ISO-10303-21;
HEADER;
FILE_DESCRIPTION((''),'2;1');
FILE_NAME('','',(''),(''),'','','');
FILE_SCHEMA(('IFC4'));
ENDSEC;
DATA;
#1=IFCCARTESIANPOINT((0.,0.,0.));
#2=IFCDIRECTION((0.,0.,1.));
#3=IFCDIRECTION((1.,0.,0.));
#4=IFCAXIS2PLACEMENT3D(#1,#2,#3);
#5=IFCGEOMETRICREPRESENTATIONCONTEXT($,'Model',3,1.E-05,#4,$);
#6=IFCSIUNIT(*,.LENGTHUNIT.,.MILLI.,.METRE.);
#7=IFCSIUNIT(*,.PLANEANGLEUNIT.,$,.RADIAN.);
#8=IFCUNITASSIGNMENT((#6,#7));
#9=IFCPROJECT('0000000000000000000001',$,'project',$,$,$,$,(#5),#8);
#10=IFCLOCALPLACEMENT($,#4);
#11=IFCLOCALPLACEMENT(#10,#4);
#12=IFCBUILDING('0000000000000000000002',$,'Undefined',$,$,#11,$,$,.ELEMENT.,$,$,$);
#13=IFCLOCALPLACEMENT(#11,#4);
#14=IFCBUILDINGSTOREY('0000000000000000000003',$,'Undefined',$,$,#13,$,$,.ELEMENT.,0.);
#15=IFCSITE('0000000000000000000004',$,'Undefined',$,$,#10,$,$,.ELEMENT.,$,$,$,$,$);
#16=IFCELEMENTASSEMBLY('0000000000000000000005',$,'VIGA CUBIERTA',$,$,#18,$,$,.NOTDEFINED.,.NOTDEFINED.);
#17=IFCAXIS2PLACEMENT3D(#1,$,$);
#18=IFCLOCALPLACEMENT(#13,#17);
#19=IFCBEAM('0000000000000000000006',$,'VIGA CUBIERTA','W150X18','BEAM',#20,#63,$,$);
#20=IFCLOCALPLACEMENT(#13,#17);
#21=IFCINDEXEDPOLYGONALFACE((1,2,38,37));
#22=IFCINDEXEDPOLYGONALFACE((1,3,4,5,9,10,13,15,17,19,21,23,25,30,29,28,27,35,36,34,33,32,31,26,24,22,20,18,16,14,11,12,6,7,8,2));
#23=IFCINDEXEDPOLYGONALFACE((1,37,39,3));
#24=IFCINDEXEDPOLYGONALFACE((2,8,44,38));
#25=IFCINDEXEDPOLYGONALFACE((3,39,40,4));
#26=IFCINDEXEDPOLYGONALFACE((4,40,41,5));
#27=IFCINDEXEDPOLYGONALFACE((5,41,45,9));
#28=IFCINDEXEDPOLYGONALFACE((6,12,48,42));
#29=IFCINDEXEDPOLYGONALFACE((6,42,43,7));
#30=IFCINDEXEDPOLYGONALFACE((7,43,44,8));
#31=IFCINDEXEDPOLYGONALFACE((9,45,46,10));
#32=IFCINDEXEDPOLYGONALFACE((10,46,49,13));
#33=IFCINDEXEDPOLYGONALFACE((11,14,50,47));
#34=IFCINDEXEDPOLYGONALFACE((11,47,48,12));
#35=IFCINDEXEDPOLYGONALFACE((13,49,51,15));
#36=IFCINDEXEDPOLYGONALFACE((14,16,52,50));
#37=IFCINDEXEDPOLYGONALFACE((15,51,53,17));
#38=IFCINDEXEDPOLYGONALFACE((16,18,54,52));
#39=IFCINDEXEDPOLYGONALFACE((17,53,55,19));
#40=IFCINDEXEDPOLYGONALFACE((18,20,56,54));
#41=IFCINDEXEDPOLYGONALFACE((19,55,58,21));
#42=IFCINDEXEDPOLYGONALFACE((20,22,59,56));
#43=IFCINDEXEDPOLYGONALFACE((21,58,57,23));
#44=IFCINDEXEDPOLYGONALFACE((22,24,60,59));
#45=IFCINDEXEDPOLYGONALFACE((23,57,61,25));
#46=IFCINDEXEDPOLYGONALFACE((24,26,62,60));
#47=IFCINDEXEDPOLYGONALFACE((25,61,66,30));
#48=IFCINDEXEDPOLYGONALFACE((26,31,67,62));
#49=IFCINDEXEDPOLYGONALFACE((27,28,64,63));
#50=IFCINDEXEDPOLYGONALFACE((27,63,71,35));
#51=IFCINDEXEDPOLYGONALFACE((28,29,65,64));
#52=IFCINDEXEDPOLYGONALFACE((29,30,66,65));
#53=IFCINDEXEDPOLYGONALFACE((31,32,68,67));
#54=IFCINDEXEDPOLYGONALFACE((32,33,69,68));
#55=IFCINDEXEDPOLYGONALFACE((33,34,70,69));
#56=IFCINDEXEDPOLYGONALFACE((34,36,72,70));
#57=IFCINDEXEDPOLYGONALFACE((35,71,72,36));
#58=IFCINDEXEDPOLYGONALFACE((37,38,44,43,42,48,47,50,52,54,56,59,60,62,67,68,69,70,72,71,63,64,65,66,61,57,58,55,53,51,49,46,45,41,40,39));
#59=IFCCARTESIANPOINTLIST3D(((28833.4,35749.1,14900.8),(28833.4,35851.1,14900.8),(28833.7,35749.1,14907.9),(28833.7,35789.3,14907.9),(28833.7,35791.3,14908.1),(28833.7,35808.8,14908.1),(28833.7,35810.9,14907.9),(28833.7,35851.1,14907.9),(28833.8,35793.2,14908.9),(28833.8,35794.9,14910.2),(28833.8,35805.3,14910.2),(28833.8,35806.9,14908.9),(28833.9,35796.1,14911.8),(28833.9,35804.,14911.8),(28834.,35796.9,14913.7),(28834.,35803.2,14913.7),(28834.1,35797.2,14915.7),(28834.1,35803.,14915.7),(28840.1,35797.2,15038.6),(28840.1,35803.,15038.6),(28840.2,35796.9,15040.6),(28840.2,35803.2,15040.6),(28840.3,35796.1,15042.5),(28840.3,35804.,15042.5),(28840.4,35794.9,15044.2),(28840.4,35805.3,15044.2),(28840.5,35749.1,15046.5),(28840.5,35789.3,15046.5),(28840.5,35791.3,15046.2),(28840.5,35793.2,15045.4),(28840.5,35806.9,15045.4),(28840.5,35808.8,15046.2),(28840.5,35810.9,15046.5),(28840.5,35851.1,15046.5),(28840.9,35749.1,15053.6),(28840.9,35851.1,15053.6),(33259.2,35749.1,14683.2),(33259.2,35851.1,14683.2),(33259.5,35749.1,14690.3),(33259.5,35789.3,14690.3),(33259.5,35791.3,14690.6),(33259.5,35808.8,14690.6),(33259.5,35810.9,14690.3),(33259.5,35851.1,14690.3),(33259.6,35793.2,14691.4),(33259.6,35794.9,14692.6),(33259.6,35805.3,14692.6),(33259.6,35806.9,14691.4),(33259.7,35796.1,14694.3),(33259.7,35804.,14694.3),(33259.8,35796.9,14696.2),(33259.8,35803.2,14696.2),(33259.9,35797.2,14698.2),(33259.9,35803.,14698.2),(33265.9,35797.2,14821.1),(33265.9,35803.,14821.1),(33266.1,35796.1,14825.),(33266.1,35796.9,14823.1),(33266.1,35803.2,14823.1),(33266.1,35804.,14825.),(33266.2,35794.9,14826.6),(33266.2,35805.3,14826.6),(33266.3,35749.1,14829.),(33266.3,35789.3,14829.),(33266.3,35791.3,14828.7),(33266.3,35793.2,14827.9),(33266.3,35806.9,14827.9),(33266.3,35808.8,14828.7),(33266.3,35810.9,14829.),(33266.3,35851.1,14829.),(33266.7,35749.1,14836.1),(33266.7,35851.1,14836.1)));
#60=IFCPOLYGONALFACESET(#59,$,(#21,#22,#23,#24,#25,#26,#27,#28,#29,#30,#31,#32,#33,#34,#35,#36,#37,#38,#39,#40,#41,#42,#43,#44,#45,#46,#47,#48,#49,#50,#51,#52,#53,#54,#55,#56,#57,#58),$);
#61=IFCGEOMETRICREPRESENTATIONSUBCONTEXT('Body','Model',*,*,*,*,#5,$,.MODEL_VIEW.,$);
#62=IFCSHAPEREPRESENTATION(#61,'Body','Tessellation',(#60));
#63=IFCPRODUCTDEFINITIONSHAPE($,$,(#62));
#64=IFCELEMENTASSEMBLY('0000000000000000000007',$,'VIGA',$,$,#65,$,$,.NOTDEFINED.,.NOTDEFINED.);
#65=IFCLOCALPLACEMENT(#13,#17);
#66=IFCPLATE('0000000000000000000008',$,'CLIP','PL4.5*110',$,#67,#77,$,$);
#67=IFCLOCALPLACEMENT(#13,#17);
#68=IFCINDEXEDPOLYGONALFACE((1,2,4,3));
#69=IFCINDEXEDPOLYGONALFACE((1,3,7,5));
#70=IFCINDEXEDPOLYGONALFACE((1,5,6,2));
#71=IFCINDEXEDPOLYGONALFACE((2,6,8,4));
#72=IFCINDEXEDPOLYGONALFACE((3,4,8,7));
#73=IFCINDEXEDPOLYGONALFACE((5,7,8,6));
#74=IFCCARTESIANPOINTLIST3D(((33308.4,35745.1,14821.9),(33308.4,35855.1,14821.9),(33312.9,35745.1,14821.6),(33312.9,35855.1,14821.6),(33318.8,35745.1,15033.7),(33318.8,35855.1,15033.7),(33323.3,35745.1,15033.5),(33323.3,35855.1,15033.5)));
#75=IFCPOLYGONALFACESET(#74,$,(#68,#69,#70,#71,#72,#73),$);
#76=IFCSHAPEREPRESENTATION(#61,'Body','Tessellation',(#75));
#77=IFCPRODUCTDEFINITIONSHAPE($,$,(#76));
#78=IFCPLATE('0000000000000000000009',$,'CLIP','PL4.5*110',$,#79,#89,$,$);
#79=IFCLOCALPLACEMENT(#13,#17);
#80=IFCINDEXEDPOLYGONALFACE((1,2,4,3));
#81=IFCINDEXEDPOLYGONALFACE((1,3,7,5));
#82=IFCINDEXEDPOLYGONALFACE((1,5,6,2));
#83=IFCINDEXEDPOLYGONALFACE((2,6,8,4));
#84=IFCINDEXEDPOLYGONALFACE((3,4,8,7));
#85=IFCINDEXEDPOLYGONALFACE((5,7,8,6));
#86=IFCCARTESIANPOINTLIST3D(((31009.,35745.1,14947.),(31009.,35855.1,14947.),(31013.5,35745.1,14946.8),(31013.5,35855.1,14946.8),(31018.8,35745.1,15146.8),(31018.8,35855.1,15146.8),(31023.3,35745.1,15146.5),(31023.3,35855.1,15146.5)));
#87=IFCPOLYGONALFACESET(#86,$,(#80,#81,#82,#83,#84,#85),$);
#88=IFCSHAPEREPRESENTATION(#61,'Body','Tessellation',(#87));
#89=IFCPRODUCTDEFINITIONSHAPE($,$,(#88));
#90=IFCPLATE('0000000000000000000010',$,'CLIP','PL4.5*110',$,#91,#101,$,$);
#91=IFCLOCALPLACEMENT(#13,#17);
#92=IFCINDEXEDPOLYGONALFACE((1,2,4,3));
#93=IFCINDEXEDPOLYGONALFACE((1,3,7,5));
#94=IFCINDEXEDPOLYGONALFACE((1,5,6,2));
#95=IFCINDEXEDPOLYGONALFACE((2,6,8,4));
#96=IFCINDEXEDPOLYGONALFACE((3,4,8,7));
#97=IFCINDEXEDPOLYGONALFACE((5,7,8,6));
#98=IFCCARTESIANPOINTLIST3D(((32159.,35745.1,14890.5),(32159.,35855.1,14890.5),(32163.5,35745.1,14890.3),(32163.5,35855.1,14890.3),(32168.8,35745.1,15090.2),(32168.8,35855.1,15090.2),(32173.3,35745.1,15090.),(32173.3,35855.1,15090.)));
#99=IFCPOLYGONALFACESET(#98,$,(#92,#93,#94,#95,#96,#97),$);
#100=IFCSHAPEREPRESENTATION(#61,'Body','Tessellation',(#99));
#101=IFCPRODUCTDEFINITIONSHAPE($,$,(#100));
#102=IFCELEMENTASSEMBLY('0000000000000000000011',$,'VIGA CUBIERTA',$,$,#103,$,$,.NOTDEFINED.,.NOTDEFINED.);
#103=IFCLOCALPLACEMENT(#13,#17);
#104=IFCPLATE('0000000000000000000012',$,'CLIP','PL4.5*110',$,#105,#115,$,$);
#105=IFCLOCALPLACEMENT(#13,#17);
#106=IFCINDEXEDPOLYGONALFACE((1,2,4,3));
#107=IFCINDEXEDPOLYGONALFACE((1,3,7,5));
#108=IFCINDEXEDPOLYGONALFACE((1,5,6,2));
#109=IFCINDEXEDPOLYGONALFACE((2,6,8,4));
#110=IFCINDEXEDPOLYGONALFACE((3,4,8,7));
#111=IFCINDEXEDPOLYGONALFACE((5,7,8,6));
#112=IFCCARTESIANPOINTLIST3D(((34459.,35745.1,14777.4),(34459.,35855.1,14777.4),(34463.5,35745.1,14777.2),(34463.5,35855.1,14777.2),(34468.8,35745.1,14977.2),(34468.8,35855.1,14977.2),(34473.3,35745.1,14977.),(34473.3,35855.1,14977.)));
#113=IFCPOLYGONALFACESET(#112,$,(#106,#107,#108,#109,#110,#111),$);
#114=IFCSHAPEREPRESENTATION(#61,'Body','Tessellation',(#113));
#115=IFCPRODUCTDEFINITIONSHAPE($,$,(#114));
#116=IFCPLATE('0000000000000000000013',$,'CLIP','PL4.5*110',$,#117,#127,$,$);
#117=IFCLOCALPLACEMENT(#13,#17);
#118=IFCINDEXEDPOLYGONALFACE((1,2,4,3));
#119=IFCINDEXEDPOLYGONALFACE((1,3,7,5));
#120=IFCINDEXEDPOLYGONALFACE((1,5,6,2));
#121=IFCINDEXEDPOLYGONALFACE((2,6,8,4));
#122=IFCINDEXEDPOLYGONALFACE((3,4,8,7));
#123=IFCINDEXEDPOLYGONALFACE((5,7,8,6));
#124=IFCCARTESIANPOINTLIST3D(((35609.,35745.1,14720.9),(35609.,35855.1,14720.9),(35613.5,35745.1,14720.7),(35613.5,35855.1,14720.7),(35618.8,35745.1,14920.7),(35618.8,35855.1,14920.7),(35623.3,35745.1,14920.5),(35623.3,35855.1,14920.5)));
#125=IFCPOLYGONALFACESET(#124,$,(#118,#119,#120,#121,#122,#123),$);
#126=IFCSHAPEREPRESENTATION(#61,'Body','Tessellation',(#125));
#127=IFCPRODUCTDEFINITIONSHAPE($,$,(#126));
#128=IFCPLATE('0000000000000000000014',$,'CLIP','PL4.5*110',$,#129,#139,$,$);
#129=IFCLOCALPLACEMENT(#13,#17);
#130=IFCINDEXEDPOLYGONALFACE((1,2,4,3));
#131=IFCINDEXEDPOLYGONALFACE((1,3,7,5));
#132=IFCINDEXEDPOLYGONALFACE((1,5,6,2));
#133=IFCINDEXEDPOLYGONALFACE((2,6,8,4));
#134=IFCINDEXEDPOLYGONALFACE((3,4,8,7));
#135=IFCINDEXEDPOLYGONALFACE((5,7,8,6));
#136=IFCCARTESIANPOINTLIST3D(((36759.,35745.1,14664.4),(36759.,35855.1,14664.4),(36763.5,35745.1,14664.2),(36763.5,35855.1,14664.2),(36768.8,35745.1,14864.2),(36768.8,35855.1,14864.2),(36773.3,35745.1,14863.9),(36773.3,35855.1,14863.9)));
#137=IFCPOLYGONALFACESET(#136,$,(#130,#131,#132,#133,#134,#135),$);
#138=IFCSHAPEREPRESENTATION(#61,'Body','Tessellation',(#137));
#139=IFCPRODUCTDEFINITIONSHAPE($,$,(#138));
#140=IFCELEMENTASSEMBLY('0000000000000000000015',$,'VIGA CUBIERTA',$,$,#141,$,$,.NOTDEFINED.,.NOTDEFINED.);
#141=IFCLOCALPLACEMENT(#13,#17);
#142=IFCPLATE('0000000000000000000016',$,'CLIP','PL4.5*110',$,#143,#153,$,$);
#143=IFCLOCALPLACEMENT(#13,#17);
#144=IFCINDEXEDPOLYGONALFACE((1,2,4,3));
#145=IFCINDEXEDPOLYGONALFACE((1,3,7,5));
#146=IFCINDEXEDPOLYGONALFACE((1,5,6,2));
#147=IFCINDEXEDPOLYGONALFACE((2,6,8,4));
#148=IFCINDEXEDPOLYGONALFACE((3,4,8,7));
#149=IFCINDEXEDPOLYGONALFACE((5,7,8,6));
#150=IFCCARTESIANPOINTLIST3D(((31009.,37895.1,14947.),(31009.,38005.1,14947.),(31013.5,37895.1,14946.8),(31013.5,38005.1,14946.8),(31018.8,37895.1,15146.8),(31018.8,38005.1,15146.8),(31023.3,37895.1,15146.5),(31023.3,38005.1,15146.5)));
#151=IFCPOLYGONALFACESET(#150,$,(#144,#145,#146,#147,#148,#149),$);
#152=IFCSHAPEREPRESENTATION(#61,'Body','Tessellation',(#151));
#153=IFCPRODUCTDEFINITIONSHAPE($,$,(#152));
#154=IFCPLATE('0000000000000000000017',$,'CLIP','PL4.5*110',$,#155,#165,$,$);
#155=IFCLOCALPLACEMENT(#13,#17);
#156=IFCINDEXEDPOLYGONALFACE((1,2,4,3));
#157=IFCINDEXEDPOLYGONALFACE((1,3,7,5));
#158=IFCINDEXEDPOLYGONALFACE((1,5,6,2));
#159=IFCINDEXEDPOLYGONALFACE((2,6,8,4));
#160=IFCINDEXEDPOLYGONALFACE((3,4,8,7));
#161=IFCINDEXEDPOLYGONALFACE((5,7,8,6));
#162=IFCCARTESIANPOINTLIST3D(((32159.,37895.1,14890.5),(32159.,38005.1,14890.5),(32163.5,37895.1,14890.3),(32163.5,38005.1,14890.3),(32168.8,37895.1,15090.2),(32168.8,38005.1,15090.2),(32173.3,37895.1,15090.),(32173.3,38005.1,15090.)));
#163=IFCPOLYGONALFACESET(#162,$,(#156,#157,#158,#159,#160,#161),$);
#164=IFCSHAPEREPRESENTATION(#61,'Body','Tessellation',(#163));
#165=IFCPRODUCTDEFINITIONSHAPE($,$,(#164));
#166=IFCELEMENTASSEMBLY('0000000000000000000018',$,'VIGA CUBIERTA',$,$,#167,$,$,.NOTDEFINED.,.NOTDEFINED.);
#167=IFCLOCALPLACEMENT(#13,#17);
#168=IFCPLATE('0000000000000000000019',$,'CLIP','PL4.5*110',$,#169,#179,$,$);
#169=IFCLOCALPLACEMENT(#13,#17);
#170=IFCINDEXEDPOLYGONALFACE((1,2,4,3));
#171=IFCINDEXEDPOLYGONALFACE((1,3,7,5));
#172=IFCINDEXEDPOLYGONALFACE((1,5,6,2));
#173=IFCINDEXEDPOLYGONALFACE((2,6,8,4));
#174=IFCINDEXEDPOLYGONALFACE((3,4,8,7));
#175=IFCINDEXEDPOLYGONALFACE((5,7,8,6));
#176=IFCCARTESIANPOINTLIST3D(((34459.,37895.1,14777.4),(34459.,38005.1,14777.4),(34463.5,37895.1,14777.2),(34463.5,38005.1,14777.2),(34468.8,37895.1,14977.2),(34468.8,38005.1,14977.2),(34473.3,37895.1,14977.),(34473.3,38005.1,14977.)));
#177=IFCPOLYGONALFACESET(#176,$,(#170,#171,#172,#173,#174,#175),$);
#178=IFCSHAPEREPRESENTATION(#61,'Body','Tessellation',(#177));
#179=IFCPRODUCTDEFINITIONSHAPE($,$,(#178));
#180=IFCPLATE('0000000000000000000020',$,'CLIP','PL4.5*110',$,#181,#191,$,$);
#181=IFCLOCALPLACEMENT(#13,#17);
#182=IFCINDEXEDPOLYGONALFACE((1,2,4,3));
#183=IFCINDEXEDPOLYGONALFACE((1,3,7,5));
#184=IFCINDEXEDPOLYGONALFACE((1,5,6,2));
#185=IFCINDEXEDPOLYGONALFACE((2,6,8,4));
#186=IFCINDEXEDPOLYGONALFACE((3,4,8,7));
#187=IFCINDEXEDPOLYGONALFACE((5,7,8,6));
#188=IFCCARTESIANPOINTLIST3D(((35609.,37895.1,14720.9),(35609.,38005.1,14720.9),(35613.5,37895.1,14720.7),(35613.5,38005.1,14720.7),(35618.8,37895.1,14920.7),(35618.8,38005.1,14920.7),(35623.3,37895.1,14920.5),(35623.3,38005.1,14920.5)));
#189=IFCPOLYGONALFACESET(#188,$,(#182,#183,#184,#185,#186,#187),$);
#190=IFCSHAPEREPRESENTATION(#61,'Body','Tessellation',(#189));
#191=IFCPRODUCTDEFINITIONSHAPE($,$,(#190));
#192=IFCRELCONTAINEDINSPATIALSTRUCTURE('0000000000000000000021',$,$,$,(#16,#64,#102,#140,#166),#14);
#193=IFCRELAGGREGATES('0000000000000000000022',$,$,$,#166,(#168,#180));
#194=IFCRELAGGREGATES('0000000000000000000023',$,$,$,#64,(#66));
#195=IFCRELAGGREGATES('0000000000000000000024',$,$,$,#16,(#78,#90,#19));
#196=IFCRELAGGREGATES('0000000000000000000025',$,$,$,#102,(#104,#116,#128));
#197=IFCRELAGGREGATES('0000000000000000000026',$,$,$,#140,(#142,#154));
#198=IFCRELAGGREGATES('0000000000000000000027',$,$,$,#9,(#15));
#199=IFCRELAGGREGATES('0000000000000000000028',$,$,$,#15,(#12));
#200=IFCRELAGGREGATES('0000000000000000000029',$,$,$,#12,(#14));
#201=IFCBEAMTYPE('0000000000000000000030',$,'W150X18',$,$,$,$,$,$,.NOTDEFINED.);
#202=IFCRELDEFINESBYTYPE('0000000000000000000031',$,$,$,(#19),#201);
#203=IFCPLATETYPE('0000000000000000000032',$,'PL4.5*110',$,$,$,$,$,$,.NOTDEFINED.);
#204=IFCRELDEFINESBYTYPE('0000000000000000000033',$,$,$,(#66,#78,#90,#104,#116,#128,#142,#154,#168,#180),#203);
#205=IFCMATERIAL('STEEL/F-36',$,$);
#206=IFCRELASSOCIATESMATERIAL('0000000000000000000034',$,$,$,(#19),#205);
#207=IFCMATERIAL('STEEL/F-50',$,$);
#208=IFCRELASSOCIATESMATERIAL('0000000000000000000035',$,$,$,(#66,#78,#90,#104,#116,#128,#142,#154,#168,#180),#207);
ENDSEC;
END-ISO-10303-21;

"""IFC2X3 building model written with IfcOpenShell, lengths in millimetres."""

from ifc_helpers import new_model, si_unit, frame, origin_with_axes, origin_2d_with_axis, place, context, subcontext, project, spatial, polyline, i_section, outline, extrude, material, type_object, element, aggregate, save


model = new_model("IFC2X3")

# Units and contexts
model_context = context("Model", 3, precision=1e-05, world=origin_with_axes())
body_context = subcontext(model_context, "Body", "Model", "MODEL_VIEW")
ifc_project = project(units=[si_unit("LENGTHUNIT", "METRE", prefix="MILLI"), si_unit("PLANEANGLEUNIT", "RADIAN")], contexts=[model_context])

# Site, building, storey
site_placement = place(None, origin_with_axes())
site = spatial("IfcSite", under=ifc_project, at=site_placement, Name="Undefined", CompositionType="ELEMENT")
building_placement = place(site_placement, origin_with_axes())
building = spatial("IfcBuilding", under=site, at=building_placement, Name="Undefined", CompositionType="ELEMENT")
storey_placement = place(building_placement, origin_with_axes())
storey = spatial("IfcBuildingStorey", under=building, at=storey_placement, Name="Undefined", CompositionType="ELEMENT", Elevation=0.0)

# Element assembly, beam
assembly_1_placement = place(storey_placement, origin_with_axes())
assembly_1 = element("IfcElementAssembly", 1, at=assembly_1_placement, inside=storey, Name="VIGA CUBIERTA", AssemblyPlace="NOTDEFINED", PredefinedType="NOTDEFINED")
ifc_material_1 = material(Name="STEEL/F-36")
beam_type = type_object("IfcBeamType", Name="W150X18", PredefinedType="NOTDEFINED")
beam_placement = place(assembly_1_placement, frame((33262.9, 35800.1, 14759.6), z_axis=(0.04909, 0.0, 0.998794), x_axis=(-0.998794, 0.0, 0.04909)))
beam = element("IfcBeam", 2, at=beam_placement, type_object=beam_type, material=ifc_material_1, Name="VIGA CUBIERTA", Description="W150X18", ObjectType="BEAM", context=body_context, shape_type="SweptSolid", body=[
    extrude(i_section(OverallWidth=102.0, OverallDepth=153.0, WebThickness=5.8, FlangeThickness=7.1, FilletRadius=7.9, at=origin_2d_with_axis()), frame((4431.1, 0.0, 0.0), z_axis=(-1.0, 0.0, 0.0), x_axis=(0.0, -1.0, 0.0)), (0.0, 0.0, 1.0), 4431.1),
])

# Element assembly, plate
assembly_2_placement = place(storey_placement, origin_with_axes())
assembly_2 = element("IfcElementAssembly", 3, at=assembly_2_placement, inside=storey, Name="VIGA", AssemblyPlace="NOTDEFINED", PredefinedType="NOTDEFINED")
ifc_material_2 = material(Name="STEEL/F-50")
plate_type_1 = type_object("IfcPlateType", Name="PL4.5*110", PredefinedType="NOTDEFINED")
plate_1_placement = place(assembly_2_placement, frame((33310.6, 35745.1, 14821.8), z_axis=(0.998794, 0.0, -0.049091), x_axis=(0.0, 1.0, 0.0)))
plate_1 = element("IfcPlate", 4, at=plate_1_placement, type_object=plate_type_1, material=ifc_material_2, Name="CLIP", Description="PL4.5*110", context=body_context, shape_type="SweptSolid", body=[
    extrude(outline(polyline([(0.0, 0.0), (110.0, 0.0), (110.0, 212.1), (0.0, 212.1), (0.0, 0.0)])), frame((0.0, 0.0, -2.2), z_axis=(0.0, 0.0, 1.0), x_axis=(1.0, 0.0, 0.0)), (0.0, 0.0, 1.0), 4.5),
])

# Plates
plate_2_placement = place(assembly_1_placement, frame((31011.2, 35745.1, 14946.9), z_axis=(0.998794, 0.0, -0.049091), x_axis=(0.0, 1.0, 0.0)))
plate_2 = element("IfcPlate", 5, at=plate_2_placement, type_object=plate_type_1, material=ifc_material_2, Name="CLIP", Description="PL4.5*110", context=body_context, shape_type="SweptSolid", body=[
    extrude(outline(polyline([(0.0, 0.0), (110.0, 0.0), (110.0, 200.0), (0.0, 200.0), (0.0, 0.0)])), frame((0.0, 0.0, -2.2), z_axis=(0.0, 0.0, 1.0), x_axis=(1.0, 0.0, 0.0)), (0.0, 0.0, 1.0), 4.5),
])
plate_3_placement = place(assembly_1_placement, frame((32161.2, 35745.1, 14890.4), z_axis=(0.998794, 0.0, -0.049091), x_axis=(0.0, 1.0, 0.0)))
plate_3 = element("IfcPlate", 6, at=plate_3_placement, type_object=plate_type_1, material=ifc_material_2, Name="CLIP", Description="PL4.5*110", context=body_context, shape_type="SweptSolid", body=[
    extrude(outline(polyline([(0.0, 0.0), (110.0, 0.0), (110.0, 200.0), (0.0, 200.0), (0.0, 0.0)])), frame((0.0, 0.0, -2.2), z_axis=(0.0, 0.0, 1.0), x_axis=(1.0, 0.0, 0.0)), (0.0, 0.0, 1.0), 4.5),
])

# Element assemblies, plates
assembly_3_placement = place(storey_placement, origin_with_axes())
assembly_3 = element("IfcElementAssembly", 7, at=assembly_3_placement, inside=storey, Name="VIGA CUBIERTA", AssemblyPlace="NOTDEFINED", PredefinedType="NOTDEFINED")
plate_4_placement = place(assembly_3_placement, frame((34461.2, 35745.1, 14777.3), z_axis=(0.998794, 0.0, -0.049091), x_axis=(0.0, 1.0, 0.0)))
plate_4 = element("IfcPlate", 8, at=plate_4_placement, type_object=plate_type_1, material=ifc_material_2, Name="CLIP", Description="PL4.5*110", context=body_context, shape_type="SweptSolid", body=[
    extrude(outline(polyline([(0.0, 0.0), (110.0, 0.0), (110.0, 200.0), (0.0, 200.0), (0.0, 0.0)])), frame((0.0, 0.0, -2.2), z_axis=(0.0, 0.0, 1.0), x_axis=(1.0, 0.0, 0.0)), (0.0, 0.0, 1.0), 4.5),
])
plate_5_placement = place(assembly_3_placement, frame((35611.2, 35745.1, 14720.8), z_axis=(0.998794, 0.0, -0.049091), x_axis=(0.0, 1.0, 0.0)))
plate_5 = element("IfcPlate", 9, at=plate_5_placement, type_object=plate_type_1, material=ifc_material_2, Name="CLIP", Description="PL4.5*110", context=body_context, shape_type="SweptSolid", body=[
    extrude(outline(polyline([(0.0, 0.0), (110.0, 0.0), (110.0, 200.0), (0.0, 200.0), (0.0, 0.0)])), frame((0.0, 0.0, -2.2), z_axis=(0.0, 0.0, 1.0), x_axis=(1.0, 0.0, 0.0)), (0.0, 0.0, 1.0), 4.5),
])
plate_6_placement = place(assembly_3_placement, frame((36761.2, 35745.1, 14664.3), z_axis=(0.998794, 0.0, -0.049091), x_axis=(0.0, 1.0, 0.0)))
plate_6 = element("IfcPlate", 10, at=plate_6_placement, type_object=plate_type_1, material=ifc_material_2, Name="CLIP", Description="PL4.5*110", context=body_context, shape_type="SweptSolid", body=[
    extrude(outline(polyline([(0.0, 0.0), (110.0, 0.0), (110.0, 200.0), (0.0, 200.0), (0.0, 0.0)])), frame((0.0, 0.0, -2.2), z_axis=(0.0, 0.0, 1.0), x_axis=(1.0, 0.0, 0.0)), (0.0, 0.0, 1.0), 4.5),
])
assembly_4_placement = place(storey_placement, origin_with_axes())
assembly_4 = element("IfcElementAssembly", 11, at=assembly_4_placement, inside=storey, Name="VIGA CUBIERTA", AssemblyPlace="NOTDEFINED", PredefinedType="NOTDEFINED")
plate_7_placement = place(assembly_4_placement, frame((31011.2, 37895.1, 14946.9), z_axis=(0.998794, 0.0, -0.049091), x_axis=(0.0, 1.0, 0.0)))
plate_7 = element("IfcPlate", 12, at=plate_7_placement, type_object=plate_type_1, material=ifc_material_2, Name="CLIP", Description="PL4.5*110", context=body_context, shape_type="SweptSolid", body=[
    extrude(outline(polyline([(0.0, 0.0), (110.0, 0.0), (110.0, 200.0), (0.0, 200.0), (0.0, 0.0)])), frame((0.0, 0.0, -2.2), z_axis=(0.0, 0.0, 1.0), x_axis=(1.0, 0.0, 0.0)), (0.0, 0.0, 1.0), 4.5),
])
plate_8_placement = place(assembly_4_placement, frame((32161.2, 37895.1, 14890.4), z_axis=(0.998794, 0.0, -0.049091), x_axis=(0.0, 1.0, 0.0)))
plate_8 = element("IfcPlate", 13, at=plate_8_placement, type_object=plate_type_1, material=ifc_material_2, Name="CLIP", Description="PL4.5*110", context=body_context, shape_type="SweptSolid", body=[
    extrude(outline(polyline([(0.0, 0.0), (110.0, 0.0), (110.0, 200.0), (0.0, 200.0), (0.0, 0.0)])), frame((0.0, 0.0, -2.2), z_axis=(0.0, 0.0, 1.0), x_axis=(1.0, 0.0, 0.0)), (0.0, 0.0, 1.0), 4.5),
])
assembly_5_placement = place(storey_placement, origin_with_axes())
assembly_5 = element("IfcElementAssembly", 14, at=assembly_5_placement, inside=storey, Name="VIGA CUBIERTA", AssemblyPlace="NOTDEFINED", PredefinedType="NOTDEFINED")
plate_9_placement = place(assembly_5_placement, frame((34461.2, 37895.1, 14777.3), z_axis=(0.998794, 0.0, -0.049091), x_axis=(0.0, 1.0, 0.0)))
plate_9 = element("IfcPlate", 15, at=plate_9_placement, type_object=plate_type_1, material=ifc_material_2, Name="CLIP", Description="PL4.5*110", context=body_context, shape_type="SweptSolid", body=[
    extrude(outline(polyline([(0.0, 0.0), (110.0, 0.0), (110.0, 200.0), (0.0, 200.0), (0.0, 0.0)])), frame((0.0, 0.0, -2.2), z_axis=(0.0, 0.0, 1.0), x_axis=(1.0, 0.0, 0.0)), (0.0, 0.0, 1.0), 4.5),
])
plate_10_placement = place(assembly_5_placement, frame((35611.2, 37895.1, 14720.8), z_axis=(0.998794, 0.0, -0.049091), x_axis=(0.0, 1.0, 0.0)))
plate_10 = element("IfcPlate", 16, at=plate_10_placement, type_object=plate_type_1, material=ifc_material_2, Name="CLIP", Description="PL4.5*110", context=body_context, shape_type="SweptSolid", body=[
    extrude(outline(polyline([(0.0, 0.0), (110.0, 0.0), (110.0, 200.0), (0.0, 200.0), (0.0, 0.0)])), frame((0.0, 0.0, -2.2), z_axis=(0.0, 0.0, 1.0), x_axis=(1.0, 0.0, 0.0)), (0.0, 0.0, 1.0), 4.5),
])
aggregate(assembly_5, [plate_9, plate_10])

aggregate(assembly_2, [plate_1])

aggregate(assembly_1, [plate_2, plate_3, beam])
aggregate(assembly_3, [plate_4, plate_5, plate_6])
aggregate(assembly_4, [plate_7, plate_8])

save(model, "model.ifc")
